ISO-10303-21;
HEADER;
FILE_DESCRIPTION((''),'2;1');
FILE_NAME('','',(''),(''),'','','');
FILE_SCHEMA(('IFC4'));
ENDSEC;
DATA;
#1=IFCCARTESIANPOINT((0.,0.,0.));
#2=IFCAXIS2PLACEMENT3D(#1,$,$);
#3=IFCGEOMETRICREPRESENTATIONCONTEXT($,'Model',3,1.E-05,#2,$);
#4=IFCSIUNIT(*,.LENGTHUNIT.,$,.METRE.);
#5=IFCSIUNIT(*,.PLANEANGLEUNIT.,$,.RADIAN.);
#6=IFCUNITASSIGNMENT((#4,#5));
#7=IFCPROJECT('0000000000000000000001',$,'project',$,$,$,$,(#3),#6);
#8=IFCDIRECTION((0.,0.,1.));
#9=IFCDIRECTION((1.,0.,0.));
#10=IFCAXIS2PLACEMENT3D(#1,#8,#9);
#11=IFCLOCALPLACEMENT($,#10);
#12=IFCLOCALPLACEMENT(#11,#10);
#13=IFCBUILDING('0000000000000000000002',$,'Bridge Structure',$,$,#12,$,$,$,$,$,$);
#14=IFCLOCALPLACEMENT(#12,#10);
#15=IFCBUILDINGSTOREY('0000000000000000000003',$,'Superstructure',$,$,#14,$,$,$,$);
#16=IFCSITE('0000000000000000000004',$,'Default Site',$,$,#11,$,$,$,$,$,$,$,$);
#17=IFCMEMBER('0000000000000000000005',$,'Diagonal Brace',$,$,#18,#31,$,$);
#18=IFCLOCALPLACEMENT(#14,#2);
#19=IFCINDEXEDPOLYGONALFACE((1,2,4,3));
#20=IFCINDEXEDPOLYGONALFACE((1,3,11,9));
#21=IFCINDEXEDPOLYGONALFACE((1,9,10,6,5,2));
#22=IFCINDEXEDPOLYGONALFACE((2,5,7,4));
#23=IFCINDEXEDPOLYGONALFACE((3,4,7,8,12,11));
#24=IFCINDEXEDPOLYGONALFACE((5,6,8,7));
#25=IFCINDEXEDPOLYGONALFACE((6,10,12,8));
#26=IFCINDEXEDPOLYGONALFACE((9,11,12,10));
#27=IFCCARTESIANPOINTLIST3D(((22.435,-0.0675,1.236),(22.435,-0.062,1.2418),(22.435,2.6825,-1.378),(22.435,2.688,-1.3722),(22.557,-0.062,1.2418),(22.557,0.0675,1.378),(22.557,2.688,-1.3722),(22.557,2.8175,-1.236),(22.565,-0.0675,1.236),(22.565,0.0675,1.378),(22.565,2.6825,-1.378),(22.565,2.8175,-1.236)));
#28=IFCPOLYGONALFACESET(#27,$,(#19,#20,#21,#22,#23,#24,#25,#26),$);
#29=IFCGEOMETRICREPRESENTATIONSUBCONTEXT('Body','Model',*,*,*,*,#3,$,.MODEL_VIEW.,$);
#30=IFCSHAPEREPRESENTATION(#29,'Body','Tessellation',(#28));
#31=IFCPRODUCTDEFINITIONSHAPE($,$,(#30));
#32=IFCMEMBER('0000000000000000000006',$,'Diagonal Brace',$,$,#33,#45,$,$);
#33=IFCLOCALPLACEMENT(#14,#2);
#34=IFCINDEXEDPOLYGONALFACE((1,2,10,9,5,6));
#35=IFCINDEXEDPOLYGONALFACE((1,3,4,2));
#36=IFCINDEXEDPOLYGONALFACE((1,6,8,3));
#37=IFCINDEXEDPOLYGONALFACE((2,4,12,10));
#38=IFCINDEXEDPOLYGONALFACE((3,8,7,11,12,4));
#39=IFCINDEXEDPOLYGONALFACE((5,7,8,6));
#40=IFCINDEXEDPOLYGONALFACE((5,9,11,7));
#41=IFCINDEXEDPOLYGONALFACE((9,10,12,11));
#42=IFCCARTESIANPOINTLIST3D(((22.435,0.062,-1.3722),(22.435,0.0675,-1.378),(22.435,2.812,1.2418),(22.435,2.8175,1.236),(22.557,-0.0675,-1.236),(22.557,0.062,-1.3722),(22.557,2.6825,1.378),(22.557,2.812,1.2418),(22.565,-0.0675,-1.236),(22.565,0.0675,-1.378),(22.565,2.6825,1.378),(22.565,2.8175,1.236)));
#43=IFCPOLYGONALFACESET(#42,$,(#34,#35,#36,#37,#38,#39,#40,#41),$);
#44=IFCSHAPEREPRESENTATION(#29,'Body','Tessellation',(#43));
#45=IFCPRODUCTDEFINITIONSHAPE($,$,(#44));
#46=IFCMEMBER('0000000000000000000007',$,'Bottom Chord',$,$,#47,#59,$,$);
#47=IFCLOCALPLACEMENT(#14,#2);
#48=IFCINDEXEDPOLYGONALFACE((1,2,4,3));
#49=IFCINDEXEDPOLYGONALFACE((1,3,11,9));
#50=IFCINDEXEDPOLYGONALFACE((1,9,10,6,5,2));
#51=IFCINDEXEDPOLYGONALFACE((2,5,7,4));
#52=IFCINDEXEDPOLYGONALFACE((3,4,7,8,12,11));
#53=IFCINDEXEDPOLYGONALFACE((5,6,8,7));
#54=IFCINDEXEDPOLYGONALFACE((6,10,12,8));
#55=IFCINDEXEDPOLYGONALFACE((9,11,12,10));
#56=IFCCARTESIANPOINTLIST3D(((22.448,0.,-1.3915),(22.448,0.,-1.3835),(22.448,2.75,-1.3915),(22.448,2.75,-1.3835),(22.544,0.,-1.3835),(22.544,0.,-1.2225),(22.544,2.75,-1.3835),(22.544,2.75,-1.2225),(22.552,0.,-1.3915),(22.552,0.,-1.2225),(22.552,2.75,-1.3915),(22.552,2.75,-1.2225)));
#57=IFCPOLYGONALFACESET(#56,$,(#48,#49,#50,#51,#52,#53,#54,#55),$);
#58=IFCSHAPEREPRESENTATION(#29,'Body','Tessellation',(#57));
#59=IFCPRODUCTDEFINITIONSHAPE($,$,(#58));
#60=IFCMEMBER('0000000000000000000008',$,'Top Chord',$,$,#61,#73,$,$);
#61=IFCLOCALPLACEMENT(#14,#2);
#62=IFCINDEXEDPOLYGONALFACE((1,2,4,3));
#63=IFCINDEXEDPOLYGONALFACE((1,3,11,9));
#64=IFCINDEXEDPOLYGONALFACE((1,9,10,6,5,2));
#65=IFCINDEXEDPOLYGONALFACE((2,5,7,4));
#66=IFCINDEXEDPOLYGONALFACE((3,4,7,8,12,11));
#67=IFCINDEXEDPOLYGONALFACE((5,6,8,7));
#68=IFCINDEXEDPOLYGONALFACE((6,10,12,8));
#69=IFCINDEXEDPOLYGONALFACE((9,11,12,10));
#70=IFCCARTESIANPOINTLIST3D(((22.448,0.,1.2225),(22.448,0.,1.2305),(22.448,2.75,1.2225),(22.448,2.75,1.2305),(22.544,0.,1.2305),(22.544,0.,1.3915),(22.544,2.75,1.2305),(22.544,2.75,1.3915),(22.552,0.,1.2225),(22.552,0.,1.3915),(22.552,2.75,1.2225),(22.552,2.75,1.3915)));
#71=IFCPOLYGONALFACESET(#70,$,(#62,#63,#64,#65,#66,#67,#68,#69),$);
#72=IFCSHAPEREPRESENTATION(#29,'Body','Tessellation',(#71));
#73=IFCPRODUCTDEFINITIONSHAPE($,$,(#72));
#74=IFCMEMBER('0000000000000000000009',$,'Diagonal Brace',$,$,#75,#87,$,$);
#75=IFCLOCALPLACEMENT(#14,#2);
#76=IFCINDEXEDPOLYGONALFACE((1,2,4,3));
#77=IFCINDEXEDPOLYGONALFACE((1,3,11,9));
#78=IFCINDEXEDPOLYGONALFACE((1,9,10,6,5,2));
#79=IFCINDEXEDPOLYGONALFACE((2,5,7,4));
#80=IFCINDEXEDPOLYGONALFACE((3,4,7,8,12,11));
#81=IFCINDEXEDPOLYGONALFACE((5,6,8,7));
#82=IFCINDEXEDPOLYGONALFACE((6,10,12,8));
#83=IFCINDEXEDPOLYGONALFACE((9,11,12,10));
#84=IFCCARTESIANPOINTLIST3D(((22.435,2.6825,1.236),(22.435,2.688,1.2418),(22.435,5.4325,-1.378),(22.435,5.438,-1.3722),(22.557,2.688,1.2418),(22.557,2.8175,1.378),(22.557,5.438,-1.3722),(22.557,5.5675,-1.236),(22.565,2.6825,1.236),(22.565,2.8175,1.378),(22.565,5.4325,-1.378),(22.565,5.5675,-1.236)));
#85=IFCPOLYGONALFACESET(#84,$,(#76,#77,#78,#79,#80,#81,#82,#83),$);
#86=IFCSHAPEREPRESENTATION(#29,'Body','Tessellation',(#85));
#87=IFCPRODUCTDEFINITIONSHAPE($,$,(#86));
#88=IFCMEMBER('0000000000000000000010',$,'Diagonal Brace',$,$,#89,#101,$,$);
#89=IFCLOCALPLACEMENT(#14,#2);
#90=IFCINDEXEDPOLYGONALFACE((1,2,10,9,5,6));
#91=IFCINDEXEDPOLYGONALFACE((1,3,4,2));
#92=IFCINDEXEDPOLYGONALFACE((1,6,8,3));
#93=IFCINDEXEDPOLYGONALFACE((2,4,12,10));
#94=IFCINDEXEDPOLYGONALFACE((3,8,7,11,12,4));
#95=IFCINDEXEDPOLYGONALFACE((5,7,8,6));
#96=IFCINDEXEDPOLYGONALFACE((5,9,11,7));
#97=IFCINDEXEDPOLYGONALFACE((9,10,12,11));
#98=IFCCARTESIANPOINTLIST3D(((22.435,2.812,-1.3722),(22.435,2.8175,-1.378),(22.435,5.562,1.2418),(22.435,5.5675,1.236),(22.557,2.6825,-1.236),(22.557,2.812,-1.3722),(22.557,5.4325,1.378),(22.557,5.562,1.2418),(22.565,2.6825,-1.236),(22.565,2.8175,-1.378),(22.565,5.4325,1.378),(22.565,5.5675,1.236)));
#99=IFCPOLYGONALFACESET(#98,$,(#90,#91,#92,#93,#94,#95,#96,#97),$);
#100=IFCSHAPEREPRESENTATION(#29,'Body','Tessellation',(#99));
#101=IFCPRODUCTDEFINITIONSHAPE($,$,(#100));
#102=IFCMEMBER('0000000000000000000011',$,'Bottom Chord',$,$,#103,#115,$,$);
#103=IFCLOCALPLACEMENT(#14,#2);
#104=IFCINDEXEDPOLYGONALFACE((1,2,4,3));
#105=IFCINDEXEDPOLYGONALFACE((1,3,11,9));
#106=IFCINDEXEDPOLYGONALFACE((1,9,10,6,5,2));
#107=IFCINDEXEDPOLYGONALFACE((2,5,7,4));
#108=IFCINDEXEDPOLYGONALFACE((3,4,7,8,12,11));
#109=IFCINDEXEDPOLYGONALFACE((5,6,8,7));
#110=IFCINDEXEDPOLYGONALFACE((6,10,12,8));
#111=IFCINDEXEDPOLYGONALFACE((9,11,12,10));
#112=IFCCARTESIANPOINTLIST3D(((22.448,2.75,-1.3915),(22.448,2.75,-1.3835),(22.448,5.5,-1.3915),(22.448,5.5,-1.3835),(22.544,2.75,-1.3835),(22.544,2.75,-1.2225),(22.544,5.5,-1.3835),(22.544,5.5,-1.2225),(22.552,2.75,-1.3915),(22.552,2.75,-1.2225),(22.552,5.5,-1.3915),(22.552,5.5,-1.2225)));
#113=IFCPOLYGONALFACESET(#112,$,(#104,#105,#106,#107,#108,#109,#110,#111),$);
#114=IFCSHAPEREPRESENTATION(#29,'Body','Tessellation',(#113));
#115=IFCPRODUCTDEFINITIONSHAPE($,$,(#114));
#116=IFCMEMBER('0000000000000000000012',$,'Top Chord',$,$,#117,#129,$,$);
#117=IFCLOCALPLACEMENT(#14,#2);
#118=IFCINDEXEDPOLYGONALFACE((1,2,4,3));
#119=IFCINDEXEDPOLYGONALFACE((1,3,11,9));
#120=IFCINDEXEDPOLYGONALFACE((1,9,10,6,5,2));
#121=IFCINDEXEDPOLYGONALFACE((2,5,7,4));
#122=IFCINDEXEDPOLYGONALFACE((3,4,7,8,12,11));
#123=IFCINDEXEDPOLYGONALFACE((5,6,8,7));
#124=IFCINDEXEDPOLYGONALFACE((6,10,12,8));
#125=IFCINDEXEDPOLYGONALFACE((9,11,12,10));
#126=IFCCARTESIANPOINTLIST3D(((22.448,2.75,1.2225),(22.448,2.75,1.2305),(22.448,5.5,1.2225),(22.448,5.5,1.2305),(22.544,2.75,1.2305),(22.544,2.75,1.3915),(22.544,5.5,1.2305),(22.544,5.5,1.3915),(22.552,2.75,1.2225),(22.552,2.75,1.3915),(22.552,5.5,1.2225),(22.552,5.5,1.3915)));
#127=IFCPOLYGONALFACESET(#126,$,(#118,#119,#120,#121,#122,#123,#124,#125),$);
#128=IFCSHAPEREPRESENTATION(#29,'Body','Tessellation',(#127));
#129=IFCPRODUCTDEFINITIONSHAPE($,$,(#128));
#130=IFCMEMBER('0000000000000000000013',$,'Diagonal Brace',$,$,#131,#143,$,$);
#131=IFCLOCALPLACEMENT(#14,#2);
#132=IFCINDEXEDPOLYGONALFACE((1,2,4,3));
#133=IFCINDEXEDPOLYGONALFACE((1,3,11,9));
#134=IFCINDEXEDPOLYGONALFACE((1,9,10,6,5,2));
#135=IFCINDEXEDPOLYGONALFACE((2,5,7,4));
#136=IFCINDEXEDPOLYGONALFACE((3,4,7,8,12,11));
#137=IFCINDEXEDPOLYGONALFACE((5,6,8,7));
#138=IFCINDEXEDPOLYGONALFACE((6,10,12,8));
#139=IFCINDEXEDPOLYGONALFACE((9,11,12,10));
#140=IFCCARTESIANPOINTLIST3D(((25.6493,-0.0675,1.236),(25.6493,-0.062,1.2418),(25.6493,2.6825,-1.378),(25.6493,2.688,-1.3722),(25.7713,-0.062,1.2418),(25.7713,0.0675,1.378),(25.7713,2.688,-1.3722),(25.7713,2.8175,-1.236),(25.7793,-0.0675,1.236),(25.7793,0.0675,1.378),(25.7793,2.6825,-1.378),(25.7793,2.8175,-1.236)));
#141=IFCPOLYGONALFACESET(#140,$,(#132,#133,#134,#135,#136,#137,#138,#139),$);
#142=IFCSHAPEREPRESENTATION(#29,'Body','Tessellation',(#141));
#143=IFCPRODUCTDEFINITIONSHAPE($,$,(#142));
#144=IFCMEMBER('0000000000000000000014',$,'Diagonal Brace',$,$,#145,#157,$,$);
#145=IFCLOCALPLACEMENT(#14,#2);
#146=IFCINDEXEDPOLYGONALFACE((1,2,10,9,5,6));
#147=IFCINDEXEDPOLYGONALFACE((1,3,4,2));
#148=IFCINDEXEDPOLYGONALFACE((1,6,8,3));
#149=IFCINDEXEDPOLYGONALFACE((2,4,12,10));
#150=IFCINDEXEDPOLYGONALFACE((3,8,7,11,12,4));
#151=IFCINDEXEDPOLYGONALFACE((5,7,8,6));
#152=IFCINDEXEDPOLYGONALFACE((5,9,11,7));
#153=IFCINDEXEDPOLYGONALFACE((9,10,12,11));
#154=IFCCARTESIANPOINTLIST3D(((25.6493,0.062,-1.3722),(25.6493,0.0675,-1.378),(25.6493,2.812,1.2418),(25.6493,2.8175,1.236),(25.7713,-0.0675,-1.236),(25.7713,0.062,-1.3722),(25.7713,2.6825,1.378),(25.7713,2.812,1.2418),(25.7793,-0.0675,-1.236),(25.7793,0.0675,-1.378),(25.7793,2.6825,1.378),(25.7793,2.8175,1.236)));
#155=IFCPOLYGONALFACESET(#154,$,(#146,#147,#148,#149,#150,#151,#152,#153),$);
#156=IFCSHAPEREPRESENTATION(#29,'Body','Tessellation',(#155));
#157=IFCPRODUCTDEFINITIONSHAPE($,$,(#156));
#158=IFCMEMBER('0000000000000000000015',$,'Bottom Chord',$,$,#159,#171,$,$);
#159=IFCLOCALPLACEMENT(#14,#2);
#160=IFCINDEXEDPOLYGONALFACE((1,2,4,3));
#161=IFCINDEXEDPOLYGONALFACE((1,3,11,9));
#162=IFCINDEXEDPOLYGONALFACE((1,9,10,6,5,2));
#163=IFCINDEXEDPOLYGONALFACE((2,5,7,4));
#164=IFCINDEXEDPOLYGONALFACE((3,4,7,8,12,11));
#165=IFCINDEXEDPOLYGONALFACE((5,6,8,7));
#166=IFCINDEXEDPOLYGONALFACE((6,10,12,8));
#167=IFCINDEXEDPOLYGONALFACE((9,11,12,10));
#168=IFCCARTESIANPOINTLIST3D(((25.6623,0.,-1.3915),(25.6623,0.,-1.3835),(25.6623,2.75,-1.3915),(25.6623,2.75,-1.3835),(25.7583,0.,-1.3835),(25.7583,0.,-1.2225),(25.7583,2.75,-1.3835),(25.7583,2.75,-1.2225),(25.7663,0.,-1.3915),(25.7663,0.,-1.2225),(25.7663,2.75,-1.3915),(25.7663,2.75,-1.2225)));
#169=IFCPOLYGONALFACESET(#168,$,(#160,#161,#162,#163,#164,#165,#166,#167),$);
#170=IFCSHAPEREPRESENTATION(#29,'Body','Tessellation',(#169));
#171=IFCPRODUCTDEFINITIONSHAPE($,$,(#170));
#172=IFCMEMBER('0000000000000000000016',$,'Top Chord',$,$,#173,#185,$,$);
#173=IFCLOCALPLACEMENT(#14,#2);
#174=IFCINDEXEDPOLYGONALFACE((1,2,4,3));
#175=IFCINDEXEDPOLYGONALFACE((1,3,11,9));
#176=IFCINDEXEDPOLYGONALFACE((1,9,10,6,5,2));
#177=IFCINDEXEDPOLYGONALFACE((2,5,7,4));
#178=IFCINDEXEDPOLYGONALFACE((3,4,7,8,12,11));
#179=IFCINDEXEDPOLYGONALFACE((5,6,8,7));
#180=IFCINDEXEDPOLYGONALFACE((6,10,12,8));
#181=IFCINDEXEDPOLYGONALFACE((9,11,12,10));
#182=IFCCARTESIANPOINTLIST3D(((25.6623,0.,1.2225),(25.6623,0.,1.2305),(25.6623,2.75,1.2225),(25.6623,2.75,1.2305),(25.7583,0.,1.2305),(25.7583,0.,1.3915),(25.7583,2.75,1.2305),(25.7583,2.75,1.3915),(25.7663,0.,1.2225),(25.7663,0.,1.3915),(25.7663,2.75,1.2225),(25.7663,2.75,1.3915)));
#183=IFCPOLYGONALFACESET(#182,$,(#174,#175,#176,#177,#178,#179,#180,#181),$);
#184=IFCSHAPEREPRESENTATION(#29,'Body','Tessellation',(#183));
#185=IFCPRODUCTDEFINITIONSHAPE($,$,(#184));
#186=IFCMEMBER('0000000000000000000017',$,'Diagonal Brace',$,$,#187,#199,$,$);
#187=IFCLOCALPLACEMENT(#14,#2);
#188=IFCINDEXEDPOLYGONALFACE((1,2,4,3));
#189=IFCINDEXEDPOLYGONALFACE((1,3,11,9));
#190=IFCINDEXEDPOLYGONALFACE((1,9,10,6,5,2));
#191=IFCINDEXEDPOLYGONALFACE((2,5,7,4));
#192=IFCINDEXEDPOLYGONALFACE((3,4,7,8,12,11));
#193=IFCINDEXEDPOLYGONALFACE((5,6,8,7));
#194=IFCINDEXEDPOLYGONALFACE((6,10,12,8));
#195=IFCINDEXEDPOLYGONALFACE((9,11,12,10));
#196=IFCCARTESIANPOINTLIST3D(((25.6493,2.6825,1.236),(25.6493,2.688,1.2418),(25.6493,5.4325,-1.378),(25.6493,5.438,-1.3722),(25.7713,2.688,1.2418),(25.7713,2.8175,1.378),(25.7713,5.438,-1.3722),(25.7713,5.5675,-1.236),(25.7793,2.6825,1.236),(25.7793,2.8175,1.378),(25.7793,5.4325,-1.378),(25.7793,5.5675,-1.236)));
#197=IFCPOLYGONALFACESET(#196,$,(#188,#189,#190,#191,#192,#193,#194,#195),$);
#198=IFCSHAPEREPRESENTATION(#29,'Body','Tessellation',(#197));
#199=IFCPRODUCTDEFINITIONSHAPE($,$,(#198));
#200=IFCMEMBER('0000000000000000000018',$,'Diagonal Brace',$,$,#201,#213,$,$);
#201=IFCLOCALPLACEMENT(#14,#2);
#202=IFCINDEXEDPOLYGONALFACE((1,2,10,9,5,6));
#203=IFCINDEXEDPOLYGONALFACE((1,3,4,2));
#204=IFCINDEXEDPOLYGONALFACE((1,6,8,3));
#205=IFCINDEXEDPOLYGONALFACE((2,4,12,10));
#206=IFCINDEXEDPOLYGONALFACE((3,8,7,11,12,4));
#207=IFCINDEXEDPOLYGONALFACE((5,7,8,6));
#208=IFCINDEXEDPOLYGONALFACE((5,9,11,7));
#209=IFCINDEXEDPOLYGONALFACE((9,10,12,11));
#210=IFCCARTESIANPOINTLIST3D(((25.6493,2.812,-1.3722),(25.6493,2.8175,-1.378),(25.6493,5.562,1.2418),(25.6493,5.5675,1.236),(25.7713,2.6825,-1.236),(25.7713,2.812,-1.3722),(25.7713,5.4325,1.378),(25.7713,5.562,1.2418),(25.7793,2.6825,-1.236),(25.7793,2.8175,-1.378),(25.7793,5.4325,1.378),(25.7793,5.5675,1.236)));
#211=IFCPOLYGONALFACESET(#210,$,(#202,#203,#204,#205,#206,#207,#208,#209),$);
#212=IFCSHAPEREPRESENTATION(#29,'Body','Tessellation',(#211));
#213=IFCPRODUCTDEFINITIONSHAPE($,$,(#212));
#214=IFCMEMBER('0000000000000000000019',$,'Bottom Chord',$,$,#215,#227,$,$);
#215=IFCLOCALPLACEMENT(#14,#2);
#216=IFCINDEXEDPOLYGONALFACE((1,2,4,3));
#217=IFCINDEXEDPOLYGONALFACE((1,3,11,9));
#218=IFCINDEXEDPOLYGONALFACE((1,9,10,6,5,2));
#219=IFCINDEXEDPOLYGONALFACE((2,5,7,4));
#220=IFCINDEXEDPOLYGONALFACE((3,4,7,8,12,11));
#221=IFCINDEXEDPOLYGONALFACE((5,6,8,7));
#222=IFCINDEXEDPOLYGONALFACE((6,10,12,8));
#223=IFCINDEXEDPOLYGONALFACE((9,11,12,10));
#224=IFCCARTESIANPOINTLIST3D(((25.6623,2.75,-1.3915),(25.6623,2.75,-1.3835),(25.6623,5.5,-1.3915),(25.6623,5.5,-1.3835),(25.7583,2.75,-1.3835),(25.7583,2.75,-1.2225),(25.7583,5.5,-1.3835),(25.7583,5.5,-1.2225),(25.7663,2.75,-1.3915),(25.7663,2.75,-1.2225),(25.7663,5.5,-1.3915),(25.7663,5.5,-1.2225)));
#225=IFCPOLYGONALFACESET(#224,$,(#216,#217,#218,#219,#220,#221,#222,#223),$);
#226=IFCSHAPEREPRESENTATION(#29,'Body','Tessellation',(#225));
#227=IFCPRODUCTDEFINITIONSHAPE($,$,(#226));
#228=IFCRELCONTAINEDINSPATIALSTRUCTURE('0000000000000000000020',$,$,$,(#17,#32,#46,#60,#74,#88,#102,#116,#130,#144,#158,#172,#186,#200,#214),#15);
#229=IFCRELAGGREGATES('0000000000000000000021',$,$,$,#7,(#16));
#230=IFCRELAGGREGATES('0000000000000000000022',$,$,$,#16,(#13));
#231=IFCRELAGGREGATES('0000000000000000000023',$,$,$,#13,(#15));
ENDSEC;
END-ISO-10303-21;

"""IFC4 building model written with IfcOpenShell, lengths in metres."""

from ifc_helpers import new_model, si_unit, frame, origin, origin_with_axes, origin_2d_with_axis, place, context, subcontext, project, spatial, l_section, extrude, element, save


model = new_model("IFC4")

# Units and contexts
model_context = context("Model", 3, precision=1e-05, world=origin())
body_context = subcontext(model_context, "Body", "Model", "MODEL_VIEW")
ifc_project = project(units=[si_unit("LENGTHUNIT", "METRE"), si_unit("PLANEANGLEUNIT", "RADIAN")], contexts=[model_context])

# Site, building, storey
site_placement = place(None, origin_with_axes())
site = spatial("IfcSite", under=ifc_project, at=site_placement, Name="Default Site")
building_placement = place(site_placement, origin_with_axes())
building = spatial("IfcBuilding", under=site, at=building_placement, Name="Bridge Structure")
storey_placement = place(building_placement, origin_with_axes())
storey = spatial("IfcBuildingStorey", under=building, at=storey_placement, Name="Superstructure")

# Members
for number, where, z_axis, x_axis, name in (
    (1, (22.5, 0.0, 1.307), (0.0, 0.724802, -0.688957), (-1.0, 0.0, 0.0), "Diagonal Brace"),
    (2, (22.5, 0.0, -1.307), (0.0, 0.724802, 0.688957), (-1.0, 0.0, 0.0), "Diagonal Brace"),
):
    element("IfcMember", number, at=place(storey_placement, frame(where, z_axis=z_axis, x_axis=x_axis)), inside=storey, Name=name, context=body_context, shape_type="SweptSolid", body=[
        extrude(l_section(Depth=0.196, Width=0.13, Thickness=0.008, at=origin_2d_with_axis()), origin_with_axes(), (0.0, 0.0, 1.0), 3.7941),
    ])
for number, where, z_axis, x_axis, name in (
    (3, (22.5, 0.0, -1.307), (0.0, 1.0, 0.0), (-1.0, 0.0, 0.0), "Bottom Chord"),
    (4, (22.5, 0.0, 1.307), (0.0, 1.0, 0.0), (-1.0, 0.0, 0.0), "Top Chord"),
):
    element("IfcMember", number, at=place(storey_placement, frame(where, z_axis=z_axis, x_axis=x_axis)), inside=storey, Name=name, context=body_context, shape_type="SweptSolid", body=[
        extrude(l_section(Depth=0.169, Width=0.104, Thickness=0.008, at=origin_2d_with_axis()), origin_with_axes(), (0.0, 0.0, 1.0), 2.75),
    ])
for number, where, z_axis, x_axis, name in (
    (5, (22.5, 2.75, 1.307), (0.0, 0.724802, -0.688957), (-1.0, 0.0, 0.0), "Diagonal Brace"),
    (6, (22.5, 2.75, -1.307), (0.0, 0.724802, 0.688957), (-1.0, 0.0, 0.0), "Diagonal Brace"),
):
    element("IfcMember", number, at=place(storey_placement, frame(where, z_axis=z_axis, x_axis=x_axis)), inside=storey, Name=name, context=body_context, shape_type="SweptSolid", body=[
        extrude(l_section(Depth=0.196, Width=0.13, Thickness=0.008, at=origin_2d_with_axis()), origin_with_axes(), (0.0, 0.0, 1.0), 3.7941),
    ])
for number, where, z_axis, x_axis, name in (
    (7, (22.5, 2.75, -1.307), (0.0, 1.0, 0.0), (-1.0, 0.0, 0.0), "Bottom Chord"),
    (8, (22.5, 2.75, 1.307), (0.0, 1.0, 0.0), (-1.0, 0.0, 0.0), "Top Chord"),
):
    element("IfcMember", number, at=place(storey_placement, frame(where, z_axis=z_axis, x_axis=x_axis)), inside=storey, Name=name, context=body_context, shape_type="SweptSolid", body=[
        extrude(l_section(Depth=0.169, Width=0.104, Thickness=0.008, at=origin_2d_with_axis()), origin_with_axes(), (0.0, 0.0, 1.0), 2.75),
    ])
for number, where, z_axis, x_axis, name in (
    (9, (25.7143, 0.0, 1.307), (0.0, 0.724802, -0.688957), (-1.0, 0.0, 0.0), "Diagonal Brace"),
    (10, (25.7143, 0.0, -1.307), (0.0, 0.724802, 0.688957), (-1.0, 0.0, 0.0), "Diagonal Brace"),
):
    element("IfcMember", number, at=place(storey_placement, frame(where, z_axis=z_axis, x_axis=x_axis)), inside=storey, Name=name, context=body_context, shape_type="SweptSolid", body=[
        extrude(l_section(Depth=0.196, Width=0.13, Thickness=0.008, at=origin_2d_with_axis()), origin_with_axes(), (0.0, 0.0, 1.0), 3.7941),
    ])
for number, where, z_axis, x_axis, name in (
    (11, (25.7143, 0.0, -1.307), (0.0, 1.0, 0.0), (-1.0, 0.0, 0.0), "Bottom Chord"),
    (12, (25.7143, 0.0, 1.307), (0.0, 1.0, 0.0), (-1.0, 0.0, 0.0), "Top Chord"),
):
    element("IfcMember", number, at=place(storey_placement, frame(where, z_axis=z_axis, x_axis=x_axis)), inside=storey, Name=name, context=body_context, shape_type="SweptSolid", body=[
        extrude(l_section(Depth=0.169, Width=0.104, Thickness=0.008, at=origin_2d_with_axis()), origin_with_axes(), (0.0, 0.0, 1.0), 2.75),
    ])
for number, where, z_axis, x_axis, name in (
    (13, (25.7143, 2.75, 1.307), (0.0, 0.724802, -0.688957), (-1.0, 0.0, 0.0), "Diagonal Brace"),
    (14, (25.7143, 2.75, -1.307), (0.0, 0.724802, 0.688957), (-1.0, 0.0, 0.0), "Diagonal Brace"),
):
    element("IfcMember", number, at=place(storey_placement, frame(where, z_axis=z_axis, x_axis=x_axis)), inside=storey, Name=name, context=body_context, shape_type="SweptSolid", body=[
        extrude(l_section(Depth=0.196, Width=0.13, Thickness=0.008, at=origin_2d_with_axis()), origin_with_axes(), (0.0, 0.0, 1.0), 3.7941),
    ])
for number, where, z_axis, x_axis, name in (
    (15, (25.7143, 2.75, -1.307), (0.0, 1.0, 0.0), (-1.0, 0.0, 0.0), "Bottom Chord"),
):
    element("IfcMember", number, at=place(storey_placement, frame(where, z_axis=z_axis, x_axis=x_axis)), inside=storey, Name=name, context=body_context, shape_type="SweptSolid", body=[
        extrude(l_section(Depth=0.169, Width=0.104, Thickness=0.008, at=origin_2d_with_axis()), origin_with_axes(), (0.0, 0.0, 1.0), 2.75),
    ])

save(model, "model.ifc")
